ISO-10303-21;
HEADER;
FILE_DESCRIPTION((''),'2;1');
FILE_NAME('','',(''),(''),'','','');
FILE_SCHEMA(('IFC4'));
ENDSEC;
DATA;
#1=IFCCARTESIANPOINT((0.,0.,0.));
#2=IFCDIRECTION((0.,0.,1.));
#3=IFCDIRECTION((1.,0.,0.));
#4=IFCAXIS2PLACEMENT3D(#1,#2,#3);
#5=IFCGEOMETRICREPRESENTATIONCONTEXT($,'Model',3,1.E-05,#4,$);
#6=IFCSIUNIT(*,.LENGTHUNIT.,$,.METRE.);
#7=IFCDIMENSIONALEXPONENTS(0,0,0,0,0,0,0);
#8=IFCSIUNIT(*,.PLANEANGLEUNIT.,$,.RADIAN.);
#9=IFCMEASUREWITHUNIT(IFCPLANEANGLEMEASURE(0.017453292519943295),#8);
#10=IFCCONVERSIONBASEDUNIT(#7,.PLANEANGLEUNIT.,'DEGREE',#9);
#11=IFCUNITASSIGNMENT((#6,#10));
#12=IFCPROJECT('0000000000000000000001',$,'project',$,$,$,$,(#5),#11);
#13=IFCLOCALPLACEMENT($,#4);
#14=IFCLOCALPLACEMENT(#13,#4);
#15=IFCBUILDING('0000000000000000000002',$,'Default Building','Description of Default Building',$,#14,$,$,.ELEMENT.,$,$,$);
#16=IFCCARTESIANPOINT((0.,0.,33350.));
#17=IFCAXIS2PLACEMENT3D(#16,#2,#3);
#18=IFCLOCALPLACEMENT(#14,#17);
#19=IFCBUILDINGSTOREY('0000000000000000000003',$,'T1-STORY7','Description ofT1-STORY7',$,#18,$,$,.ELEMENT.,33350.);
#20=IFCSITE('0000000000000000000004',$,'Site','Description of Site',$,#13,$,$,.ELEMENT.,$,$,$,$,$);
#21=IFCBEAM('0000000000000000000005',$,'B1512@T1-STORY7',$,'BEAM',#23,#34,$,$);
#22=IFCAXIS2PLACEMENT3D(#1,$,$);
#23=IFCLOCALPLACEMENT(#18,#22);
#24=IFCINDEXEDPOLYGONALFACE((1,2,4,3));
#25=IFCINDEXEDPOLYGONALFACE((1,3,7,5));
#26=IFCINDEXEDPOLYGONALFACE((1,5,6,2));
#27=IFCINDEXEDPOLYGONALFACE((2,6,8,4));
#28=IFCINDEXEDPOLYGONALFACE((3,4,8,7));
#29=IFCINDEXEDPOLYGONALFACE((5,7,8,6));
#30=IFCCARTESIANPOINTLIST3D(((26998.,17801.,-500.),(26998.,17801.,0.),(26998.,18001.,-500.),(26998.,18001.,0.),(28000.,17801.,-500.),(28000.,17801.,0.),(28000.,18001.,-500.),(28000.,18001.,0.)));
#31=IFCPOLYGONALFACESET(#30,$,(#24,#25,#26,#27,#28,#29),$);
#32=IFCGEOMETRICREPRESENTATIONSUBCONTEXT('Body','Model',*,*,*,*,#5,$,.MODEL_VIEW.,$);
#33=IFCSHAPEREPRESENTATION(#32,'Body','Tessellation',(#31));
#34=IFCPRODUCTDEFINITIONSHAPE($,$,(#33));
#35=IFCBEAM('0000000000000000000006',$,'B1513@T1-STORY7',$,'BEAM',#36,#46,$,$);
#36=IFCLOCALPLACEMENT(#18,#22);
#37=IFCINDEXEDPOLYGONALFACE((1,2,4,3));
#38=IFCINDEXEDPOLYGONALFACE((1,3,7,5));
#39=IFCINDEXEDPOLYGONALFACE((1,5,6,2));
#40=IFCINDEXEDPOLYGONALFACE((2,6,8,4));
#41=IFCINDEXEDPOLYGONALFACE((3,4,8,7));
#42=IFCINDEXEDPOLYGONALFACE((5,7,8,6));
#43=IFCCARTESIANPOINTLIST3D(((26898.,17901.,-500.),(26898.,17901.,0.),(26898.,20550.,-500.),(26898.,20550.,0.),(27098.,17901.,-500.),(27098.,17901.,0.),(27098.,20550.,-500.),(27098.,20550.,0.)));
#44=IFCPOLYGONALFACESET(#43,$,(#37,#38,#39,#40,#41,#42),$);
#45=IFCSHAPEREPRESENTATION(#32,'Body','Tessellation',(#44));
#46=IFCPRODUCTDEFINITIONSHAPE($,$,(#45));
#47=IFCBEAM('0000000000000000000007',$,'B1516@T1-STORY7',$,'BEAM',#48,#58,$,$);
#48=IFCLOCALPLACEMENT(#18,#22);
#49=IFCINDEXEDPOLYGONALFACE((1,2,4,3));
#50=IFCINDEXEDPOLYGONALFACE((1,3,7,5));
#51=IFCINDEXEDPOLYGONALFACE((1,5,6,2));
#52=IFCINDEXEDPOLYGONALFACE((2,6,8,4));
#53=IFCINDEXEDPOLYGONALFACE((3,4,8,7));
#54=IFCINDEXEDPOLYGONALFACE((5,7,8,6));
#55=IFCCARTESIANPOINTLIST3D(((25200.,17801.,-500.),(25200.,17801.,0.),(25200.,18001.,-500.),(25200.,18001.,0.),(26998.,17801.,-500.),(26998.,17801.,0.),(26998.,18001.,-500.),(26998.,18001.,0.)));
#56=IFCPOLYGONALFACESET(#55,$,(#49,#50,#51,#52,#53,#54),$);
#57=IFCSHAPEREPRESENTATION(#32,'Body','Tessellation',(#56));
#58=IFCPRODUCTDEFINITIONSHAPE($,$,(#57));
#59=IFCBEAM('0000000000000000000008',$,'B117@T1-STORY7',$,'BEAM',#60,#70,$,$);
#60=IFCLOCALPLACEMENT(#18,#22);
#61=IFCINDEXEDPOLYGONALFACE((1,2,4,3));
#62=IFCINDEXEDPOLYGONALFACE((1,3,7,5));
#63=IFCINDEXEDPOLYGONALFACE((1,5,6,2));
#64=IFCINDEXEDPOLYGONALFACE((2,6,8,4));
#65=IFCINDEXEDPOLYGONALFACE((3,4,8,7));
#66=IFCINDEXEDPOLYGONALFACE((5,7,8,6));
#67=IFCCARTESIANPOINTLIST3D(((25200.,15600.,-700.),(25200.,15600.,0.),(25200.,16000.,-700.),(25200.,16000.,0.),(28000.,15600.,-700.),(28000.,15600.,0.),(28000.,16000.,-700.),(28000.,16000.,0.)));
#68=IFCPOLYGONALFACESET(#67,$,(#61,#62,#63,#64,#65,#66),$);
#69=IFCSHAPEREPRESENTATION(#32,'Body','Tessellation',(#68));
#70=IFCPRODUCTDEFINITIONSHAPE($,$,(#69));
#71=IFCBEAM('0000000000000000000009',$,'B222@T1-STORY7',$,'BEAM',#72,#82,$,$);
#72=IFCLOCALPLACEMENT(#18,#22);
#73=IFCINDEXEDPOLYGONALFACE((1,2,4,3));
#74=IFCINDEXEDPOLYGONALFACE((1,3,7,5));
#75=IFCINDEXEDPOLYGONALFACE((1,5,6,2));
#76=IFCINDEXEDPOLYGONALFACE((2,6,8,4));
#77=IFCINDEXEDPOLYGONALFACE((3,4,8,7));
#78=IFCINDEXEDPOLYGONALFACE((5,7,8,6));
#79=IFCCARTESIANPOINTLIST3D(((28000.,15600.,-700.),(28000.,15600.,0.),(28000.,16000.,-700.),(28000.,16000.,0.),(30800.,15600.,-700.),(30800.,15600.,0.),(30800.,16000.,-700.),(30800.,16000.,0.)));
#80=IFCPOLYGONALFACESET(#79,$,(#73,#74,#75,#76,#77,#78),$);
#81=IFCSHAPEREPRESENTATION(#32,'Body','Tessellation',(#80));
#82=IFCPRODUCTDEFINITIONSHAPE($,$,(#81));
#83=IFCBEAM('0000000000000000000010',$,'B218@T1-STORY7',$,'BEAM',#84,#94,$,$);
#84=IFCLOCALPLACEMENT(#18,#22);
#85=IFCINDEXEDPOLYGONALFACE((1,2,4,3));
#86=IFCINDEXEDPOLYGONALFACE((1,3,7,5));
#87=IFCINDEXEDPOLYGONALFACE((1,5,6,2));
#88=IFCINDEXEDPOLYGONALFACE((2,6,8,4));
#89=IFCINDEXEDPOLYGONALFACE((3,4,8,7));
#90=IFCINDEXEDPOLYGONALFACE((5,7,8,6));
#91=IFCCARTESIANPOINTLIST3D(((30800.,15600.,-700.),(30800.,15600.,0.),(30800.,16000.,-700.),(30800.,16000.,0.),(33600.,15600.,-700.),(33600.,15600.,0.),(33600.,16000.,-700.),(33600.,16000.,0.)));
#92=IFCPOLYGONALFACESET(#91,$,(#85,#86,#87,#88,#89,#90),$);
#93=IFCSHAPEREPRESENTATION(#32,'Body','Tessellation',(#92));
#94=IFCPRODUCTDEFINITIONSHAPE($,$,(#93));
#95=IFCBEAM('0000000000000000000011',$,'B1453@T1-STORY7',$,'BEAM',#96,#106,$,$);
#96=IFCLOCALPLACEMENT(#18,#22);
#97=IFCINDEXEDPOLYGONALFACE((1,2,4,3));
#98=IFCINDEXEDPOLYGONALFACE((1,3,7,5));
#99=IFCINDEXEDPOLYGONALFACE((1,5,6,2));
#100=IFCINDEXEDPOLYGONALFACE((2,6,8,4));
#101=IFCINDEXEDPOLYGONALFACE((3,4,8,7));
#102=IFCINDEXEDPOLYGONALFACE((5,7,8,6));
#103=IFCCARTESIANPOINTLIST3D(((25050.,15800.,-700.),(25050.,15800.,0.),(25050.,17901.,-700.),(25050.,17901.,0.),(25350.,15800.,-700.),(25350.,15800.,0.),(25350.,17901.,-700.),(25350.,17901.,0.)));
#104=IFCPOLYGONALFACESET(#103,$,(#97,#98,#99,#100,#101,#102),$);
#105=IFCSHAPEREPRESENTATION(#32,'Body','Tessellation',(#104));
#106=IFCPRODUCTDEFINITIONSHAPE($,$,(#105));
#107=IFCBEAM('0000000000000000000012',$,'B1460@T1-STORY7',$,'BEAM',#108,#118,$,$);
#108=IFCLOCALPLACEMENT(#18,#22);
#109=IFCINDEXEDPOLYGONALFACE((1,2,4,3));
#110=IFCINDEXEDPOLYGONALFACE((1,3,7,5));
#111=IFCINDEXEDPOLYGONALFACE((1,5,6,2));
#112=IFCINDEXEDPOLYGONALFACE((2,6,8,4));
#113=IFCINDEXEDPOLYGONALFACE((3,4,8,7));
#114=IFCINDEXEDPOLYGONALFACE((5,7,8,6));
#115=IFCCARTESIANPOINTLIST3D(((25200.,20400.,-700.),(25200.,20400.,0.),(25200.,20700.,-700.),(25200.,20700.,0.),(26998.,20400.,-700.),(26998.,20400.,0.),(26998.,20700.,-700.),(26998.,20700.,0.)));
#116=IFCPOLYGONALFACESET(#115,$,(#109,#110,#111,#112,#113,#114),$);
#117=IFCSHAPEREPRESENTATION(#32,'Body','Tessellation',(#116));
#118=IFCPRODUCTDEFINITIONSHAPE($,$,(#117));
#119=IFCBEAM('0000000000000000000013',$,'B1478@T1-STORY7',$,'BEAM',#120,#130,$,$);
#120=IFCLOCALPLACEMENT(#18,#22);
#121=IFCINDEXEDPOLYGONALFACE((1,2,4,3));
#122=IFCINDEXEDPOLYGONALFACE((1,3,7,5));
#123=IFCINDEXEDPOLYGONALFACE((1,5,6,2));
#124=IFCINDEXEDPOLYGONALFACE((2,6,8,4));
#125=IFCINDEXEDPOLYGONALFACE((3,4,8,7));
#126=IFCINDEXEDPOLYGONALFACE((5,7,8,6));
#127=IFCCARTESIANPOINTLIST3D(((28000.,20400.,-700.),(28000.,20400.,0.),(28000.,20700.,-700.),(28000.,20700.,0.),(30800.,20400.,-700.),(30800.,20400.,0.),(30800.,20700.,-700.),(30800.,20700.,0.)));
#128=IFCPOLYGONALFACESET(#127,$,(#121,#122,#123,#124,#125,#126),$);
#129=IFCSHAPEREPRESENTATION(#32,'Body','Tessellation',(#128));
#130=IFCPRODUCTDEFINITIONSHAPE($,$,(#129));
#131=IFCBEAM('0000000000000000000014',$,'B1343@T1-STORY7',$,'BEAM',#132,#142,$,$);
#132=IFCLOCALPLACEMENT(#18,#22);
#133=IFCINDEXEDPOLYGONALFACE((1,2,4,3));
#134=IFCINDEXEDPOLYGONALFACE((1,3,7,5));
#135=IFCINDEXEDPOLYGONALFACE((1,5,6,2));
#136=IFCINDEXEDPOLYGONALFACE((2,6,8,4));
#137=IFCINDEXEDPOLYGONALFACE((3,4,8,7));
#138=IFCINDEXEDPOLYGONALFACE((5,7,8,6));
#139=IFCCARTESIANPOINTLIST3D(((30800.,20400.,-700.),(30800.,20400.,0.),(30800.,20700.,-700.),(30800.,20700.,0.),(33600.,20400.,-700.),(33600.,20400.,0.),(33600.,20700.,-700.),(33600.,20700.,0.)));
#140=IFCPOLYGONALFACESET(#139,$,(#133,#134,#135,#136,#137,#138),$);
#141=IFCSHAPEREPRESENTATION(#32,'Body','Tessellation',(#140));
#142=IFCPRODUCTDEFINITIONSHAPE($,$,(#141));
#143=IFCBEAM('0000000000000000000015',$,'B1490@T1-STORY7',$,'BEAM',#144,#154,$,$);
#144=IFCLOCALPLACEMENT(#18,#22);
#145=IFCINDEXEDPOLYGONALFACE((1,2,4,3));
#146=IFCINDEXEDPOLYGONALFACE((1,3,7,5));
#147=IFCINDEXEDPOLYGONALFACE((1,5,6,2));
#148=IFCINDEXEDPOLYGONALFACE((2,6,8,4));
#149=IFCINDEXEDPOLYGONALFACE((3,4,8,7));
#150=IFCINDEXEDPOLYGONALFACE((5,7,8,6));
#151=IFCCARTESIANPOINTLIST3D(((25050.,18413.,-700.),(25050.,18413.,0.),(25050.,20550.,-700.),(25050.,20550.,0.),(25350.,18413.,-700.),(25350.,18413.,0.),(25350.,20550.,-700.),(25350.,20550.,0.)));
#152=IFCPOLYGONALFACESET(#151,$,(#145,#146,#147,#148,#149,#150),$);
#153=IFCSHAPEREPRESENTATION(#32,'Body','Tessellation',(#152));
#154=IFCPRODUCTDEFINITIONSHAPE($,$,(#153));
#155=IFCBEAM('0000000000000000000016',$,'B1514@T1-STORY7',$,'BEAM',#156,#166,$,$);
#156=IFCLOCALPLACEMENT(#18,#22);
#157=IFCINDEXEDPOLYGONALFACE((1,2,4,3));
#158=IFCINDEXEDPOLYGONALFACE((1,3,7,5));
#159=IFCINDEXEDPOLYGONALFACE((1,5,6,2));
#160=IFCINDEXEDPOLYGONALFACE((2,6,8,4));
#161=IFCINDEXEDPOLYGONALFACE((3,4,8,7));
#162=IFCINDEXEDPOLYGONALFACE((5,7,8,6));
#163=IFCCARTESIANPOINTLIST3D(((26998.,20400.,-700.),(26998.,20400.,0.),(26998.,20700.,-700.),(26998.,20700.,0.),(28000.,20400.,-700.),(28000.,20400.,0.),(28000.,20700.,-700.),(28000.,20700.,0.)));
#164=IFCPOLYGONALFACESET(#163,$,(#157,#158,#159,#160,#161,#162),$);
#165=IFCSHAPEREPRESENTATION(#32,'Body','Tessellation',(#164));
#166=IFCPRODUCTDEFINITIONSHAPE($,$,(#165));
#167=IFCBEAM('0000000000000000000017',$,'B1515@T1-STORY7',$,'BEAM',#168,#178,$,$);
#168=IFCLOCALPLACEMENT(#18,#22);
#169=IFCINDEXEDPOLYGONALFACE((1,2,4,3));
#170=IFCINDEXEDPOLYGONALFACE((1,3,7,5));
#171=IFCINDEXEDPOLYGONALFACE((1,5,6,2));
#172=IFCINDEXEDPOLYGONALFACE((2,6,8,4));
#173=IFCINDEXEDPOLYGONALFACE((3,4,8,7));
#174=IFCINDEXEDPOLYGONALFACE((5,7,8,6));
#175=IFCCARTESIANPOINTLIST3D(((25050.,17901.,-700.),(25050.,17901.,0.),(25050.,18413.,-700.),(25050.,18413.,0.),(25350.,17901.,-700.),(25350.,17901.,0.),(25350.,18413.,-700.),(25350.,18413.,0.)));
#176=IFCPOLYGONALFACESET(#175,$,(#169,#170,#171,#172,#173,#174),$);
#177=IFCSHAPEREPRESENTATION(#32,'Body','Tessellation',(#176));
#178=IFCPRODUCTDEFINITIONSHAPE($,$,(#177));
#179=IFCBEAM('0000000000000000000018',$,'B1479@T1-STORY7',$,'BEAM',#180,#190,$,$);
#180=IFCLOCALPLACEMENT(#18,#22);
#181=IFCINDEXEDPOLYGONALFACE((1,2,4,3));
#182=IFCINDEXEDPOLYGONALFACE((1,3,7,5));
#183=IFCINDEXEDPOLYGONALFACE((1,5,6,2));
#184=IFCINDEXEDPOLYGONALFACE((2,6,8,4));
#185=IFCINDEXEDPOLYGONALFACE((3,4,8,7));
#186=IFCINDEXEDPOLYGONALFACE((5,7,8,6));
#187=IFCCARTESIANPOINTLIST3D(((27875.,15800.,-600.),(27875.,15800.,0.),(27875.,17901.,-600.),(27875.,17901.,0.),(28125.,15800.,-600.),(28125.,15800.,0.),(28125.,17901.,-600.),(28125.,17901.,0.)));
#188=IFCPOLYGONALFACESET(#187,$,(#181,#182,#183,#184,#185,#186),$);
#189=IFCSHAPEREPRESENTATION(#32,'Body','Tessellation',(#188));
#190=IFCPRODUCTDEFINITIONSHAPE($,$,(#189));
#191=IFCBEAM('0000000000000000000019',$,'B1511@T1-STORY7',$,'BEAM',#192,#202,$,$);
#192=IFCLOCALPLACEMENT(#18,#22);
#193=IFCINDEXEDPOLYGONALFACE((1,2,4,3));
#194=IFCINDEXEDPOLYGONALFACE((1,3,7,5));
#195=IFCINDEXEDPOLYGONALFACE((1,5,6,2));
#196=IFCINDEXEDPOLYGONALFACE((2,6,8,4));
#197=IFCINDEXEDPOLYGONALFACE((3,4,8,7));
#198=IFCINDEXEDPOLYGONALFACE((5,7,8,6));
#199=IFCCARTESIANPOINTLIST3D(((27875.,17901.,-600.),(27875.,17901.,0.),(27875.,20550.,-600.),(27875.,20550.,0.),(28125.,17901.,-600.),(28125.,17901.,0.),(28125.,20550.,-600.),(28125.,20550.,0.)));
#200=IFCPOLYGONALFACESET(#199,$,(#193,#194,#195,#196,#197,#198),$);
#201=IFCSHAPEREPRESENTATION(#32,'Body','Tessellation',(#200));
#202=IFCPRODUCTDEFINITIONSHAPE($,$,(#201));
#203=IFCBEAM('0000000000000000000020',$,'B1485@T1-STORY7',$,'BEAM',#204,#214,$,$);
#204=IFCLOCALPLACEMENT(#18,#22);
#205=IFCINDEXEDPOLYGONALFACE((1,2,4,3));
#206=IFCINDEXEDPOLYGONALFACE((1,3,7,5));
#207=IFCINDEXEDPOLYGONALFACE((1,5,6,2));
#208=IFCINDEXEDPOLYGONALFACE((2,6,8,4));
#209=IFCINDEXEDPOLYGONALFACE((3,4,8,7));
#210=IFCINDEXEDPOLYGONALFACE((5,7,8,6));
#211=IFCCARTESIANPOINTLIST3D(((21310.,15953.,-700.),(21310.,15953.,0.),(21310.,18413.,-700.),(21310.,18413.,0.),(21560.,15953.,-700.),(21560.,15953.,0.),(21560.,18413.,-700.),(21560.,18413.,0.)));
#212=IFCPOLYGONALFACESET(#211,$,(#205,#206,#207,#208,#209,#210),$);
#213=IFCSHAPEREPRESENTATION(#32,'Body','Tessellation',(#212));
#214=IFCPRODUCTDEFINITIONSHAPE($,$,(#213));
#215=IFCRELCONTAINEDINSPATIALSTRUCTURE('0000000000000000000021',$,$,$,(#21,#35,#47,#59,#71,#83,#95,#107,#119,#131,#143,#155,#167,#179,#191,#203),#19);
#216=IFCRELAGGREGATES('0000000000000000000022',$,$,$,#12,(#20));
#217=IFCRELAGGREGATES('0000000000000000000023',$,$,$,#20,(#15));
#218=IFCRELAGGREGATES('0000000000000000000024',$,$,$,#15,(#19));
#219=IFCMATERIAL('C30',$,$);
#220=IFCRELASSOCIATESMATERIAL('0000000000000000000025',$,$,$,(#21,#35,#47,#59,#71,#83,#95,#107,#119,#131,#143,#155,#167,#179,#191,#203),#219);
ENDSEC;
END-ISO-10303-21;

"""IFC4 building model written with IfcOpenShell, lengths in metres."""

from ifc_helpers import new_model, entity, si_unit, converted_unit, frame, origin_with_axes, place, context, subcontext, project, spatial, rectangle, extrude, material, element, save


model = new_model("IFC4")

# Units and contexts
model_context = context("Model", 3, precision=1e-05, world=origin_with_axes())
body_context = subcontext(model_context, "Body", "Model", "MODEL_VIEW")
ifc_project = project(units=[si_unit("LENGTHUNIT", "METRE"), converted_unit("PLANEANGLEUNIT", "DEGREE", entity("IfcPlaneAngleMeasure", 0.017453292519943295), si_unit("PLANEANGLEUNIT", "RADIAN"), dimensions=[0, 0, 0, 0, 0, 0, 0])], contexts=[model_context])

# Site, building, storey
site_placement = place(None, origin_with_axes())
site = spatial("IfcSite", under=ifc_project, at=site_placement, Name="Site", Description="Description of Site", CompositionType="ELEMENT")
building_placement = place(site_placement, origin_with_axes())
building = spatial("IfcBuilding", under=site, at=building_placement, Name="Default Building", Description="Description of Default Building", CompositionType="ELEMENT")
storey_placement = place(building_placement, frame((0.0, 0.0, 33350.0), z_axis=(0.0, 0.0, 1.0), x_axis=(1.0, 0.0, 0.0)))
storey = spatial("IfcBuildingStorey", under=building, at=storey_placement, Name="T1-STORY7", Description="Description ofT1-STORY7", CompositionType="ELEMENT", Elevation=33350.0)

# Beams
ifc_material_1 = material(Name="C30")
beam_1_placement = place(storey_placement, frame((26998.0, 17901.0, -250.0), z_axis=(1.0, 0.0, 0.0), x_axis=(0.0, 1.0, 0.0)))
element("IfcBeam", 1, at=beam_1_placement, inside=storey, material=ifc_material_1, Name="B1512@T1-STORY7", ObjectType="BEAM", context=body_context, shape_type="SweptSolid", body=[
    extrude(rectangle(XDim=200.0, YDim=500.0), origin_with_axes(), (0.0, 0.0, 1.0), 1002.0),
])
beam_2_placement = place(storey_placement, frame((26998.0, 17901.0, -250.0), z_axis=(0.0, 1.0, 0.0), x_axis=(-1.0, 0.0, 0.0)))
element("IfcBeam", 2, at=beam_2_placement, inside=storey, material=ifc_material_1, Name="B1513@T1-STORY7", ObjectType="BEAM", context=body_context, shape_type="SweptSolid", body=[
    extrude(rectangle(XDim=200.0, YDim=500.0), origin_with_axes(), (0.0, 0.0, 1.0), 2649.0),
])
beam_3_placement = place(storey_placement, frame((25200.0, 17901.0, -250.0), z_axis=(1.0, 0.0, 0.0), x_axis=(0.0, 1.0, 0.0)))
element("IfcBeam", 3, at=beam_3_placement, inside=storey, material=ifc_material_1, Name="B1516@T1-STORY7", ObjectType="BEAM", context=body_context, shape_type="SweptSolid", body=[
    extrude(rectangle(XDim=200.0, YDim=500.0), origin_with_axes(), (0.0, 0.0, 1.0), 1798.0),
])
for number, where, z_axis, x_axis, name in (
    (4, (25200.0, 15800.0, -350.0), (1.0, 0.0, 0.0), (0.0, 1.0, 0.0), "B117@T1-STORY7"),
    (5, (28000.0, 15800.0, -350.0), (1.0, 0.0, 0.0), (0.0, 1.0, 0.0), "B222@T1-STORY7"),
    (6, (30800.0, 15800.0, -350.0), (1.0, 0.0, 0.0), (0.0, 1.0, 0.0), "B218@T1-STORY7"),
):
    element("IfcBeam", number, at=place(storey_placement, frame(where, z_axis=z_axis, x_axis=x_axis)), inside=storey, material=ifc_material_1, Name=name, ObjectType="BEAM", context=body_context, shape_type="SweptSolid", body=[
        extrude(rectangle(XDim=400.0, YDim=700.0), origin_with_axes(), (0.0, 0.0, 1.0), 2800.0),
    ])
beam_4_placement = place(storey_placement, frame((25200.0, 15800.0, -350.0), z_axis=(0.0, 1.0, 0.0), x_axis=(-1.0, 0.0, 0.0)))
element("IfcBeam", 7, at=beam_4_placement, inside=storey, material=ifc_material_1, Name="B1453@T1-STORY7", ObjectType="BEAM", context=body_context, shape_type="SweptSolid", body=[
    extrude(rectangle(XDim=300.0, YDim=700.0), origin_with_axes(), (0.0, 0.0, 1.0), 2101.0),
])
beam_5_placement = place(storey_placement, frame((25200.0, 20550.0, -350.0), z_axis=(1.0, 0.0, 0.0), x_axis=(0.0, 1.0, 0.0)))
element("IfcBeam", 8, at=beam_5_placement, inside=storey, material=ifc_material_1, Name="B1460@T1-STORY7", ObjectType="BEAM", context=body_context, shape_type="SweptSolid", body=[
    extrude(rectangle(XDim=300.0, YDim=700.0), origin_with_axes(), (0.0, 0.0, 1.0), 1798.0),
])
for number, where, z_axis, x_axis, name in (
    (9, (28000.0, 20550.0, -350.0), (1.0, 0.0, 0.0), (0.0, 1.0, 0.0), "B1478@T1-STORY7"),
    (10, (30800.0, 20550.0, -350.0), (1.0, 0.0, 0.0), (0.0, 1.0, 0.0), "B1343@T1-STORY7"),
):
    element("IfcBeam", number, at=place(storey_placement, frame(where, z_axis=z_axis, x_axis=x_axis)), inside=storey, material=ifc_material_1, Name=name, ObjectType="BEAM", context=body_context, shape_type="SweptSolid", body=[
        extrude(rectangle(XDim=300.0, YDim=700.0), origin_with_axes(), (0.0, 0.0, 1.0), 2800.0),
    ])
beam_6_placement = place(storey_placement, frame((25200.0, 18413.0, -350.0), z_axis=(0.0, 1.0, 0.0), x_axis=(-1.0, 0.0, 0.0)))
element("IfcBeam", 11, at=beam_6_placement, inside=storey, material=ifc_material_1, Name="B1490@T1-STORY7", ObjectType="BEAM", context=body_context, shape_type="SweptSolid", body=[
    extrude(rectangle(XDim=300.0, YDim=700.0), origin_with_axes(), (0.0, 0.0, 1.0), 2137.0),
])
beam_7_placement = place(storey_placement, frame((26998.0, 20550.0, -350.0), z_axis=(1.0, 0.0, 0.0), x_axis=(0.0, 1.0, 0.0)))
element("IfcBeam", 12, at=beam_7_placement, inside=storey, material=ifc_material_1, Name="B1514@T1-STORY7", ObjectType="BEAM", context=body_context, shape_type="SweptSolid", body=[
    extrude(rectangle(XDim=300.0, YDim=700.0), origin_with_axes(), (0.0, 0.0, 1.0), 1002.0),
])
beam_8_placement = place(storey_placement, frame((25200.0, 17901.0, -350.0), z_axis=(0.0, 1.0, 0.0), x_axis=(-1.0, 0.0, 0.0)))
element("IfcBeam", 13, at=beam_8_placement, inside=storey, material=ifc_material_1, Name="B1515@T1-STORY7", ObjectType="BEAM", context=body_context, shape_type="SweptSolid", body=[
    extrude(rectangle(XDim=300.0, YDim=700.0), origin_with_axes(), (0.0, 0.0, 1.0), 512.0),
])
beam_9_placement = place(storey_placement, frame((28000.0, 15800.0, -300.0), z_axis=(0.0, 1.0, 0.0), x_axis=(-1.0, 0.0, 0.0)))
element("IfcBeam", 14, at=beam_9_placement, inside=storey, material=ifc_material_1, Name="B1479@T1-STORY7", ObjectType="BEAM", context=body_context, shape_type="SweptSolid", body=[
    extrude(rectangle(XDim=250.0, YDim=600.0), origin_with_axes(), (0.0, 0.0, 1.0), 2101.0),
])
beam_10_placement = place(storey_placement, frame((28000.0, 17901.0, -300.0), z_axis=(0.0, 1.0, 0.0), x_axis=(-1.0, 0.0, 0.0)))
element("IfcBeam", 15, at=beam_10_placement, inside=storey, material=ifc_material_1, Name="B1511@T1-STORY7", ObjectType="BEAM", context=body_context, shape_type="SweptSolid", body=[
    extrude(rectangle(XDim=250.0, YDim=600.0), origin_with_axes(), (0.0, 0.0, 1.0), 2649.0),
])
beam_11_placement = place(storey_placement, frame((21435.0, 15953.0, -350.0), z_axis=(0.0, 1.0, 0.0), x_axis=(-1.0, 0.0, 0.0)))
element("IfcBeam", 16, at=beam_11_placement, inside=storey, material=ifc_material_1, Name="B1485@T1-STORY7", ObjectType="BEAM", context=body_context, shape_type="SweptSolid", body=[
    extrude(rectangle(XDim=250.0, YDim=700.0), origin_with_axes(), (0.0, 0.0, 1.0), 2460.0),
])

save(model, "model.ifc")
